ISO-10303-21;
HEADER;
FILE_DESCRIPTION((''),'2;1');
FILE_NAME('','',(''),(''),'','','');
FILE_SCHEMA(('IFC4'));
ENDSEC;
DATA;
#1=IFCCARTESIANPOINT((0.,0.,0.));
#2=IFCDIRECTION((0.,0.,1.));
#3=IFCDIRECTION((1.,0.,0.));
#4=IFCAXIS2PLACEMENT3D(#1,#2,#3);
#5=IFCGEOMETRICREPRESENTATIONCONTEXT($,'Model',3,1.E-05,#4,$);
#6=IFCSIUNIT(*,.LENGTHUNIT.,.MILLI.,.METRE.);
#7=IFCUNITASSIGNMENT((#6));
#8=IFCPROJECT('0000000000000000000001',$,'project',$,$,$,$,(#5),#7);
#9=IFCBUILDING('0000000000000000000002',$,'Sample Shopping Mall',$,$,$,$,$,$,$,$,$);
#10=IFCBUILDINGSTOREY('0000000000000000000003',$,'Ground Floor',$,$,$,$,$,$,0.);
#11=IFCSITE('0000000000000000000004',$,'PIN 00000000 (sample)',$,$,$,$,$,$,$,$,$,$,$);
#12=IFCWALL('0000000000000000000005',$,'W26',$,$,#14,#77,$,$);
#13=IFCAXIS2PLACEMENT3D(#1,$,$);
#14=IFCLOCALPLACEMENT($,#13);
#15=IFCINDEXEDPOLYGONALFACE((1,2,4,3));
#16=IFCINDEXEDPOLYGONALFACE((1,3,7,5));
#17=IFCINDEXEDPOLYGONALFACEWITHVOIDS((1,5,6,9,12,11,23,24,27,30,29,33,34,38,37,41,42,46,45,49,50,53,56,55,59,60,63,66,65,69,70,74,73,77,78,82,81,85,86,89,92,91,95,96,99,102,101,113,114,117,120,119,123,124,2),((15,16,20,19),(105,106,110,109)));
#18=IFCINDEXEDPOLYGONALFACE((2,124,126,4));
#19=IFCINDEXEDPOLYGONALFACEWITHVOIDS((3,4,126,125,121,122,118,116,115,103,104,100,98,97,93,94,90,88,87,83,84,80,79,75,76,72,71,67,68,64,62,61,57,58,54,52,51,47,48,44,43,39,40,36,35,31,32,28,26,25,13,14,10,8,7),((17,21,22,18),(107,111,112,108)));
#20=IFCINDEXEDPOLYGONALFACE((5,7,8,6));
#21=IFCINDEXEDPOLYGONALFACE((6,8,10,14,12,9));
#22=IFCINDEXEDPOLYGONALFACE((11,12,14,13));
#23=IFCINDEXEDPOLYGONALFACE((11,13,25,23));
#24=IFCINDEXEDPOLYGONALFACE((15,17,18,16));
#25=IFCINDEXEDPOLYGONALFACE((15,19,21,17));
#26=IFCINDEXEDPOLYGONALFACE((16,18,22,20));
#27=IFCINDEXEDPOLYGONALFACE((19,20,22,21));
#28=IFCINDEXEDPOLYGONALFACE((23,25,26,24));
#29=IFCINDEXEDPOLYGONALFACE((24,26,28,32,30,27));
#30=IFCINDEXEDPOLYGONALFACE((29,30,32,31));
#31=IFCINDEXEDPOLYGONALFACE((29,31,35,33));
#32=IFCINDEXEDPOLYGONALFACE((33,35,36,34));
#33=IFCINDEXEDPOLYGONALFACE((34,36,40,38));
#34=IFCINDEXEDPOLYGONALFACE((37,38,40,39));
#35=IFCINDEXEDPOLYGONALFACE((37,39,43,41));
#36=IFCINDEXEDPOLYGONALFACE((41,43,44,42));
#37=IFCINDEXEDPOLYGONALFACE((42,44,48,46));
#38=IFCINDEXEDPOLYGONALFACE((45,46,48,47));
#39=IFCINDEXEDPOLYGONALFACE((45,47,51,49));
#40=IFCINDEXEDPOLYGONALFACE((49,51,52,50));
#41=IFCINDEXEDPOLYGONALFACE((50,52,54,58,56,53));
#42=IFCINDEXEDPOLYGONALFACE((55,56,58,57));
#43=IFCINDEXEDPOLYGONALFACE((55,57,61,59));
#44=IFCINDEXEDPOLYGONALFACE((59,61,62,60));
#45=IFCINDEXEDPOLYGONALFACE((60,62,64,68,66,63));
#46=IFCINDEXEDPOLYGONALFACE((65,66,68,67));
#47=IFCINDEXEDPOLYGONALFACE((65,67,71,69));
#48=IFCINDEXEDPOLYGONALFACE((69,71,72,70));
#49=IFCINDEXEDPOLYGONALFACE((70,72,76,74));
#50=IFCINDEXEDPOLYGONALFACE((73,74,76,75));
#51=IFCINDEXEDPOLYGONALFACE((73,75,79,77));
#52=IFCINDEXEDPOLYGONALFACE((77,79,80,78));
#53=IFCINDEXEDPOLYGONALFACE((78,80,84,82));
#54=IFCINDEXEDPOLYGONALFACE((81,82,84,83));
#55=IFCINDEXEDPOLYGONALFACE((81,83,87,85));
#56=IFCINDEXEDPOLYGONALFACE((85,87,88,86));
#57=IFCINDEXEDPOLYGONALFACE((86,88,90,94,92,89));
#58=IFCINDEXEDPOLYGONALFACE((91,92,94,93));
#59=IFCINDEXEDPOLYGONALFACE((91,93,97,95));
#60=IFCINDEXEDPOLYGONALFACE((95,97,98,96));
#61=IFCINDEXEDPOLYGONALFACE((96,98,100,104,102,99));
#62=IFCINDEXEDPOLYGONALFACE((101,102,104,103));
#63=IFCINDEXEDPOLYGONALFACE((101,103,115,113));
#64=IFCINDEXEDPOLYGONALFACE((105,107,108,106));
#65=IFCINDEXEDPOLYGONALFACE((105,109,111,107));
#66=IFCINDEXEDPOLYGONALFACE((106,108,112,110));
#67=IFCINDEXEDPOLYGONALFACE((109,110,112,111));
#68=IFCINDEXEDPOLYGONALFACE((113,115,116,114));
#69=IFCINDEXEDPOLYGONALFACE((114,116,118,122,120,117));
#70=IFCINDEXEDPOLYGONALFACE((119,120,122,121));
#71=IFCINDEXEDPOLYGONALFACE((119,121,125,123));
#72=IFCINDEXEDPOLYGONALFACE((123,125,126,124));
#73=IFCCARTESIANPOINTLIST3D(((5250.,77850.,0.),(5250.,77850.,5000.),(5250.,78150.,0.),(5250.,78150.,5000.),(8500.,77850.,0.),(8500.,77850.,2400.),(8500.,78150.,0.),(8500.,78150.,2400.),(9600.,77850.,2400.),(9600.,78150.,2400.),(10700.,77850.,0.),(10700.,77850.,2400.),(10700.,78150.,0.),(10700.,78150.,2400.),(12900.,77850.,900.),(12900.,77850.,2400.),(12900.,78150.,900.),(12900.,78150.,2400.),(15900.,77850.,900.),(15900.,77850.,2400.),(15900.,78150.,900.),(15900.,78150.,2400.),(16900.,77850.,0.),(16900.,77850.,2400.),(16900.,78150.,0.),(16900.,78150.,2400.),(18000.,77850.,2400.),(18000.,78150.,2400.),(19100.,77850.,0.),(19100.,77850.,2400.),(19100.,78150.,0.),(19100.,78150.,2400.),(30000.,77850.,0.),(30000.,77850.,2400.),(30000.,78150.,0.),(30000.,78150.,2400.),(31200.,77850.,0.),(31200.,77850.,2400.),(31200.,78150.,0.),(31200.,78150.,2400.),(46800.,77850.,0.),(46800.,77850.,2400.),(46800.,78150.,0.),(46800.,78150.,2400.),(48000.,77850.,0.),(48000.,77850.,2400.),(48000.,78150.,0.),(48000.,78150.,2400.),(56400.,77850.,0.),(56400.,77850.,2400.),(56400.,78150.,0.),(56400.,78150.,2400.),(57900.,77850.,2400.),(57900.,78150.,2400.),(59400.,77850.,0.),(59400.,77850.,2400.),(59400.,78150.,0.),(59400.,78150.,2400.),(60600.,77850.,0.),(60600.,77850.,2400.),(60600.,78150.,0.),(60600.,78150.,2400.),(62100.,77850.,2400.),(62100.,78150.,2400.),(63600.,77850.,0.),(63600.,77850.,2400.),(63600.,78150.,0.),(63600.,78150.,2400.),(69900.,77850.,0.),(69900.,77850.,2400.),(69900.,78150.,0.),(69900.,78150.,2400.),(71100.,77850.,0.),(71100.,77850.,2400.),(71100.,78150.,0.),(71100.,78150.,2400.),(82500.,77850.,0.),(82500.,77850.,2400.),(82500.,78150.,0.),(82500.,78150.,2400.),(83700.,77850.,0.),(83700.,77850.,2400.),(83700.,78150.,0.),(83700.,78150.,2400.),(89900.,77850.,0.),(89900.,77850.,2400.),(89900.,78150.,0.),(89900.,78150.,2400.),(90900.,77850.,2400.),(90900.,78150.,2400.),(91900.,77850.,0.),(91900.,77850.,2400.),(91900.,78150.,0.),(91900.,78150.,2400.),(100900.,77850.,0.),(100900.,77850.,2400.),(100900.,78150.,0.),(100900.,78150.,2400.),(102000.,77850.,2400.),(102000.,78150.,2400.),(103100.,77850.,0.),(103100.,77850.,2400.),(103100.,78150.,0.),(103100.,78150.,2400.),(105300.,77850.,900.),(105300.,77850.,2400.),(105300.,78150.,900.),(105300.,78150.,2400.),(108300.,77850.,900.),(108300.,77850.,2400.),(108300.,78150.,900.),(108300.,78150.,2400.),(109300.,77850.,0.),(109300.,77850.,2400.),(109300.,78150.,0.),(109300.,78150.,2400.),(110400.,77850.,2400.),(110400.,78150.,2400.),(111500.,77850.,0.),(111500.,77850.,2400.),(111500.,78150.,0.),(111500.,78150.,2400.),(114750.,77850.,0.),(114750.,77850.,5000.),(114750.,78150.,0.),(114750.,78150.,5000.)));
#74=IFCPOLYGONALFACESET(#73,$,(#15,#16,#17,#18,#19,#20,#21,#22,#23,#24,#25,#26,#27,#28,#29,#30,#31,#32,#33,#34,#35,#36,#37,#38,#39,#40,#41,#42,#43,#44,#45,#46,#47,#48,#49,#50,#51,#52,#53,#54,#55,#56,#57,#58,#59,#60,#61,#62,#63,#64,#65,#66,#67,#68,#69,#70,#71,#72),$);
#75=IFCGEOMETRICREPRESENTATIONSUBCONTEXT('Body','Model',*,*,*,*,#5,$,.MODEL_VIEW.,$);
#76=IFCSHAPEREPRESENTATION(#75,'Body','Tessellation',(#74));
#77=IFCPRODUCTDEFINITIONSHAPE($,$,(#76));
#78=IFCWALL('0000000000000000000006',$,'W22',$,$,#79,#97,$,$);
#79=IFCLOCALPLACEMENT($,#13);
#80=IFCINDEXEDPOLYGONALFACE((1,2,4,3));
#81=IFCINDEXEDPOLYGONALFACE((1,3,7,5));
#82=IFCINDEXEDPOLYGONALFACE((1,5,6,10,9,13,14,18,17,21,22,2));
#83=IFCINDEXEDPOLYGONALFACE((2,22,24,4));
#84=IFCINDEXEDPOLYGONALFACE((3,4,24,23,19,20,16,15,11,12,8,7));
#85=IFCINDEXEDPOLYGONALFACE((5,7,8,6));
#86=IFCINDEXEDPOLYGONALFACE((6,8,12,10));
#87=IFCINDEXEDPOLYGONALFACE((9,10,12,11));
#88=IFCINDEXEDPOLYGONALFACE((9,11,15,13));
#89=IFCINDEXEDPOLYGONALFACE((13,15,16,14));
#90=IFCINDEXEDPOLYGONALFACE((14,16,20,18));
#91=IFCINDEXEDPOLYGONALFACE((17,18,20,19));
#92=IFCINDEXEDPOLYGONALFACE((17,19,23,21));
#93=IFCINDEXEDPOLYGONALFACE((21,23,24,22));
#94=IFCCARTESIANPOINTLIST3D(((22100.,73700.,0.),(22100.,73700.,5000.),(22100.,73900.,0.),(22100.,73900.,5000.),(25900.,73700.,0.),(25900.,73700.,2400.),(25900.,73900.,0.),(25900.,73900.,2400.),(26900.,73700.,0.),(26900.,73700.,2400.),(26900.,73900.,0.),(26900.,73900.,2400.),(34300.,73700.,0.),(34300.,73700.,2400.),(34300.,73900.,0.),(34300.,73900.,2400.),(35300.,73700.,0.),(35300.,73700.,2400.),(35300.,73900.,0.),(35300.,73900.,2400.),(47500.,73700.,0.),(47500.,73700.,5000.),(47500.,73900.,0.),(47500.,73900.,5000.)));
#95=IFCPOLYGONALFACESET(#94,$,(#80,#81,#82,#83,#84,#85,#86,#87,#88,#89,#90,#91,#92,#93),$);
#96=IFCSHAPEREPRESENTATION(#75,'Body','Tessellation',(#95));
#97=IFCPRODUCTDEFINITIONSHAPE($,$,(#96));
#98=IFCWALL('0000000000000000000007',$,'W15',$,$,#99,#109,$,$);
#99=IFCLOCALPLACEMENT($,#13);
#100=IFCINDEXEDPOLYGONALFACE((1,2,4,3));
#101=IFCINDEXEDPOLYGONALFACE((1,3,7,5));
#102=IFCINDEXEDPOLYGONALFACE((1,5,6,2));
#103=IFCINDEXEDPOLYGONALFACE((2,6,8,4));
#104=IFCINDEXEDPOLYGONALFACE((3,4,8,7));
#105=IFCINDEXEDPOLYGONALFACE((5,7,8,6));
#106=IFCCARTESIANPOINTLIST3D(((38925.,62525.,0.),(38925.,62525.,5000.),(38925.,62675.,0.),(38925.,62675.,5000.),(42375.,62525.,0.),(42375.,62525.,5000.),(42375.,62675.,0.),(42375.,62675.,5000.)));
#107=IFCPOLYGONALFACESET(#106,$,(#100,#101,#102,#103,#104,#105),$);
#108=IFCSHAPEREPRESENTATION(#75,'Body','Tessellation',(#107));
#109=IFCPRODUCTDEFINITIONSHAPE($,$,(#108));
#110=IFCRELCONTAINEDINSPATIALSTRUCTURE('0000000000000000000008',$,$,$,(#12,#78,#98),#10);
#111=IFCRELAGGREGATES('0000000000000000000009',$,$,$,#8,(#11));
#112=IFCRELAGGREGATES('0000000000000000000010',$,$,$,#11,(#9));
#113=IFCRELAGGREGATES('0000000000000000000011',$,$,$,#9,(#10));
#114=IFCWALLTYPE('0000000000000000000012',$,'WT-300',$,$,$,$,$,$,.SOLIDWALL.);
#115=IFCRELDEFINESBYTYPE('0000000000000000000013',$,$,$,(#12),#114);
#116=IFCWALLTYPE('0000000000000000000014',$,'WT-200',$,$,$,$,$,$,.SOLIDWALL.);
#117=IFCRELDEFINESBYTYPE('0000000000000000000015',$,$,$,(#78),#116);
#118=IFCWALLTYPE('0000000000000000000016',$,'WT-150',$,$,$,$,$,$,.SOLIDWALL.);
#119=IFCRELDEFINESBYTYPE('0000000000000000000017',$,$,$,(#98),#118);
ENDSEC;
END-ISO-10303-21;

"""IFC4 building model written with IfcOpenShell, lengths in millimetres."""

from ifc_helpers import new_model, si_unit, frame, origin_with_axes, place, context, subcontext, project, spatial, indexed_curve, outline, extrude, type_object, element, save


model = new_model("IFC4")

# Units and contexts
model_context = context("Model", 3, precision=1e-05, world=origin_with_axes())
body_context = subcontext(model_context, "Body", "Model", "MODEL_VIEW")
ifc_project = project(units=[si_unit("LENGTHUNIT", "METRE", prefix="MILLI")], contexts=[model_context])

# Site, building, storey
site = spatial("IfcSite", under=ifc_project, Name="PIN 00000000 (sample)")
building = spatial("IfcBuilding", under=site, Name="Sample Shopping Mall")
storey = spatial("IfcBuildingStorey", under=building, Name="Ground Floor", Elevation=0.0)

# Walls, openings
wall_type_1 = type_object("IfcWallType", Name="WT-300", PredefinedType="SOLIDWALL")
wall_1_placement = place(None, frame((5250.0, 77850.0, 0.0), z_axis=(0.0, 0.0, 1.0), x_axis=(1.0, 0.0, 0.0)))
wall_1 = element("IfcWall", 1, at=wall_1_placement, inside=storey, type_object=wall_type_1, Name="W26", context=body_context, shape_type="SweptSolid", body=[
    extrude(outline(indexed_curve([(0.0, 0.0), (0.0, 300.0), (109500.0, 300.0), (109500.0, 0.0), (0.0, 0.0)], self_intersect=False)), origin_with_axes(), (0.0, 0.0, 1.0), 5000.0),
])
opening_1_placement = place(wall_1_placement, frame((3250.0, -100.0, 0.0), z_axis=(0.0, 0.0, 1.0), x_axis=(1.0, 0.0, 0.0)))
element("IfcOpeningElement", 2, at=opening_1_placement, cuts=wall_1, context=body_context, shape_type="SweptSolid", body=[
    extrude(outline(indexed_curve([(0.0, 0.0), (0.0, 500.0), (1100.0, 500.0), (1100.0, 0.0), (0.0, 0.0)], self_intersect=False)), origin_with_axes(), (0.0, 0.0, 1.0), 2400.0),
])
opening_2_placement = place(wall_1_placement, frame((4350.0, -100.0, 0.0), z_axis=(0.0, 0.0, 1.0), x_axis=(1.0, 0.0, 0.0)))
element("IfcOpeningElement", 3, at=opening_2_placement, cuts=wall_1, context=body_context, shape_type="SweptSolid", body=[
    extrude(outline(indexed_curve([(0.0, 0.0), (0.0, 500.0), (1100.0, 500.0), (1100.0, 0.0), (0.0, 0.0)], self_intersect=False)), origin_with_axes(), (0.0, 0.0, 1.0), 2400.0),
])
opening_3_placement = place(wall_1_placement, frame((11650.0, -100.0, 0.0), z_axis=(0.0, 0.0, 1.0), x_axis=(1.0, 0.0, 0.0)))
element("IfcOpeningElement", 4, at=opening_3_placement, cuts=wall_1, context=body_context, shape_type="SweptSolid", body=[
    extrude(outline(indexed_curve([(0.0, 0.0), (0.0, 500.0), (1100.0, 500.0), (1100.0, 0.0), (0.0, 0.0)], self_intersect=False)), origin_with_axes(), (0.0, 0.0, 1.0), 2400.0),
])
opening_4_placement = place(wall_1_placement, frame((12750.0, -100.0, 0.0), z_axis=(0.0, 0.0, 1.0), x_axis=(1.0, 0.0, 0.0)))
element("IfcOpeningElement", 5, at=opening_4_placement, cuts=wall_1, context=body_context, shape_type="SweptSolid", body=[
    extrude(outline(indexed_curve([(0.0, 0.0), (0.0, 500.0), (1100.0, 500.0), (1100.0, 0.0), (0.0, 0.0)], self_intersect=False)), origin_with_axes(), (0.0, 0.0, 1.0), 2400.0),
])
opening_5_placement = place(wall_1_placement, frame((95650.0, -100.0, 0.0), z_axis=(0.0, 0.0, 1.0), x_axis=(1.0, 0.0, 0.0)))
element("IfcOpeningElement", 6, at=opening_5_placement, cuts=wall_1, context=body_context, shape_type="SweptSolid", body=[
    extrude(outline(indexed_curve([(0.0, 0.0), (0.0, 500.0), (1100.0, 500.0), (1100.0, 0.0), (0.0, 0.0)], self_intersect=False)), origin_with_axes(), (0.0, 0.0, 1.0), 2400.0),
])
opening_6_placement = place(wall_1_placement, frame((96750.0, -100.0, 0.0), z_axis=(0.0, 0.0, 1.0), x_axis=(1.0, 0.0, 0.0)))
element("IfcOpeningElement", 7, at=opening_6_placement, cuts=wall_1, context=body_context, shape_type="SweptSolid", body=[
    extrude(outline(indexed_curve([(0.0, 0.0), (0.0, 500.0), (1100.0, 500.0), (1100.0, 0.0), (0.0, 0.0)], self_intersect=False)), origin_with_axes(), (0.0, 0.0, 1.0), 2400.0),
])
opening_7_placement = place(wall_1_placement, frame((104050.0, -100.0, 0.0), z_axis=(0.0, 0.0, 1.0), x_axis=(1.0, 0.0, 0.0)))
element("IfcOpeningElement", 8, at=opening_7_placement, cuts=wall_1, context=body_context, shape_type="SweptSolid", body=[
    extrude(outline(indexed_curve([(0.0, 0.0), (0.0, 500.0), (1100.0, 500.0), (1100.0, 0.0), (0.0, 0.0)], self_intersect=False)), origin_with_axes(), (0.0, 0.0, 1.0), 2400.0),
])
opening_8_placement = place(wall_1_placement, frame((105150.0, -100.0, 0.0), z_axis=(0.0, 0.0, 1.0), x_axis=(1.0, 0.0, 0.0)))
element("IfcOpeningElement", 9, at=opening_8_placement, cuts=wall_1, context=body_context, shape_type="SweptSolid", body=[
    extrude(outline(indexed_curve([(0.0, 0.0), (0.0, 500.0), (1100.0, 500.0), (1100.0, 0.0), (0.0, 0.0)], self_intersect=False)), origin_with_axes(), (0.0, 0.0, 1.0), 2400.0),
])
opening_9_placement = place(wall_1_placement, frame((24750.0, -100.0, 0.0), z_axis=(0.0, 0.0, 1.0), x_axis=(1.0, 0.0, 0.0)))
element("IfcOpeningElement", 10, at=opening_9_placement, cuts=wall_1, context=body_context, shape_type="SweptSolid", body=[
    extrude(outline(indexed_curve([(0.0, 0.0), (0.0, 500.0), (1200.0, 500.0), (1200.0, 0.0), (0.0, 0.0)], self_intersect=False)), origin_with_axes(), (0.0, 0.0, 1.0), 2400.0),
])
opening_10_placement = place(wall_1_placement, frame((41550.0, -100.0, 0.0), z_axis=(0.0, 0.0, 1.0), x_axis=(1.0, 0.0, 0.0)))
element("IfcOpeningElement", 11, at=opening_10_placement, cuts=wall_1, context=body_context, shape_type="SweptSolid", body=[
    extrude(outline(indexed_curve([(0.0, 0.0), (0.0, 500.0), (1200.0, 500.0), (1200.0, 0.0), (0.0, 0.0)], self_intersect=False)), origin_with_axes(), (0.0, 0.0, 1.0), 2400.0),
])
opening_11_placement = place(wall_1_placement, frame((64650.0, -100.0, 0.0), z_axis=(0.0, 0.0, 1.0), x_axis=(1.0, 0.0, 0.0)))
element("IfcOpeningElement", 12, at=opening_11_placement, cuts=wall_1, context=body_context, shape_type="SweptSolid", body=[
    extrude(outline(indexed_curve([(0.0, 0.0), (0.0, 500.0), (1200.0, 500.0), (1200.0, 0.0), (0.0, 0.0)], self_intersect=False)), origin_with_axes(), (0.0, 0.0, 1.0), 2400.0),
])
opening_12_placement = place(wall_1_placement, frame((77250.0, -100.0, 0.0), z_axis=(0.0, 0.0, 1.0), x_axis=(1.0, 0.0, 0.0)))
element("IfcOpeningElement", 13, at=opening_12_placement, cuts=wall_1, context=body_context, shape_type="SweptSolid", body=[
    extrude(outline(indexed_curve([(0.0, 0.0), (0.0, 500.0), (1200.0, 500.0), (1200.0, 0.0), (0.0, 0.0)], self_intersect=False)), origin_with_axes(), (0.0, 0.0, 1.0), 2400.0),
])
opening_13_placement = place(wall_1_placement, frame((51150.0, -100.0, 0.0), z_axis=(0.0, 0.0, 1.0), x_axis=(1.0, 0.0, 0.0)))
element("IfcOpeningElement", 14, at=opening_13_placement, cuts=wall_1, context=body_context, shape_type="SweptSolid", body=[
    extrude(outline(indexed_curve([(0.0, 0.0), (0.0, 500.0), (1500.0, 500.0), (1500.0, 0.0), (0.0, 0.0)], self_intersect=False)), origin_with_axes(), (0.0, 0.0, 1.0), 2400.0),
])
opening_14_placement = place(wall_1_placement, frame((52650.0, -100.0, 0.0), z_axis=(0.0, 0.0, 1.0), x_axis=(1.0, 0.0, 0.0)))
element("IfcOpeningElement", 15, at=opening_14_placement, cuts=wall_1, context=body_context, shape_type="SweptSolid", body=[
    extrude(outline(indexed_curve([(0.0, 0.0), (0.0, 500.0), (1500.0, 500.0), (1500.0, 0.0), (0.0, 0.0)], self_intersect=False)), origin_with_axes(), (0.0, 0.0, 1.0), 2400.0),
])
opening_15_placement = place(wall_1_placement, frame((55350.0, -100.0, 0.0), z_axis=(0.0, 0.0, 1.0), x_axis=(1.0, 0.0, 0.0)))
element("IfcOpeningElement", 16, at=opening_15_placement, cuts=wall_1, context=body_context, shape_type="SweptSolid", body=[
    extrude(outline(indexed_curve([(0.0, 0.0), (0.0, 500.0), (1500.0, 500.0), (1500.0, 0.0), (0.0, 0.0)], self_intersect=False)), origin_with_axes(), (0.0, 0.0, 1.0), 2400.0),
])
opening_16_placement = place(wall_1_placement, frame((56850.0, -100.0, 0.0), z_axis=(0.0, 0.0, 1.0), x_axis=(1.0, 0.0, 0.0)))
element("IfcOpeningElement", 17, at=opening_16_placement, cuts=wall_1, context=body_context, shape_type="SweptSolid", body=[
    extrude(outline(indexed_curve([(0.0, 0.0), (0.0, 500.0), (1500.0, 500.0), (1500.0, 0.0), (0.0, 0.0)], self_intersect=False)), origin_with_axes(), (0.0, 0.0, 1.0), 2400.0),
])
opening_17_placement = place(wall_1_placement, frame((84650.0, -100.0, 0.0), z_axis=(0.0, 0.0, 1.0), x_axis=(1.0, 0.0, 0.0)))
element("IfcOpeningElement", 18, at=opening_17_placement, cuts=wall_1, context=body_context, shape_type="SweptSolid", body=[
    extrude(outline(indexed_curve([(0.0, 0.0), (0.0, 500.0), (1000.0, 500.0), (1000.0, 0.0), (0.0, 0.0)], self_intersect=False)), origin_with_axes(), (0.0, 0.0, 1.0), 2400.0),
])
opening_18_placement = place(wall_1_placement, frame((85650.0, -100.0, 0.0), z_axis=(0.0, 0.0, 1.0), x_axis=(1.0, 0.0, 0.0)))
element("IfcOpeningElement", 19, at=opening_18_placement, cuts=wall_1, context=body_context, shape_type="SweptSolid", body=[
    extrude(outline(indexed_curve([(0.0, 0.0), (0.0, 500.0), (1000.0, 500.0), (1000.0, 0.0), (0.0, 0.0)], self_intersect=False)), origin_with_axes(), (0.0, 0.0, 1.0), 2400.0),
])
opening_19_placement = place(wall_1_placement, frame((7650.0, -100.0, 900.0), z_axis=(0.0, 0.0, 1.0), x_axis=(1.0, 0.0, 0.0)))
element("IfcOpeningElement", 20, at=opening_19_placement, cuts=wall_1, context=body_context, shape_type="SweptSolid", body=[
    extrude(outline(indexed_curve([(0.0, 0.0), (0.0, 500.0), (3000.0, 500.0), (3000.0, 0.0), (0.0, 0.0)], self_intersect=False)), origin_with_axes(), (0.0, 0.0, 1.0), 1500.0),
])
opening_20_placement = place(wall_1_placement, frame((100050.0, -100.0, 900.0), z_axis=(0.0, 0.0, 1.0), x_axis=(1.0, 0.0, 0.0)))
element("IfcOpeningElement", 21, at=opening_20_placement, cuts=wall_1, context=body_context, shape_type="SweptSolid", body=[
    extrude(outline(indexed_curve([(0.0, 0.0), (0.0, 500.0), (3000.0, 500.0), (3000.0, 0.0), (0.0, 0.0)], self_intersect=False)), origin_with_axes(), (0.0, 0.0, 1.0), 1500.0),
])
wall_type_2 = type_object("IfcWallType", Name="WT-200", PredefinedType="SOLIDWALL")
wall_2_placement = place(None, frame((22100.0, 73700.0, 0.0), z_axis=(0.0, 0.0, 1.0), x_axis=(1.0, 0.0, 0.0)))
wall_2 = element("IfcWall", 22, at=wall_2_placement, inside=storey, type_object=wall_type_2, Name="W22", context=body_context, shape_type="SweptSolid", body=[
    extrude(outline(indexed_curve([(0.0, 0.0), (0.0, 200.0), (25400.0, 200.0), (25400.0, 0.0), (0.0, 0.0)], self_intersect=False)), origin_with_axes(), (0.0, 0.0, 1.0), 5000.0),
])
opening_21_placement = place(wall_2_placement, frame((3800.0, -100.0, 0.0), z_axis=(0.0, 0.0, 1.0), x_axis=(1.0, 0.0, 0.0)))
element("IfcOpeningElement", 23, at=opening_21_placement, cuts=wall_2, context=body_context, shape_type="SweptSolid", body=[
    extrude(outline(indexed_curve([(0.0, 0.0), (0.0, 400.0), (1000.0, 400.0), (1000.0, 0.0), (0.0, 0.0)], self_intersect=False)), origin_with_axes(), (0.0, 0.0, 1.0), 2400.0),
])
opening_22_placement = place(wall_2_placement, frame((12200.0, -100.0, 0.0), z_axis=(0.0, 0.0, 1.0), x_axis=(1.0, 0.0, 0.0)))
element("IfcOpeningElement", 24, at=opening_22_placement, cuts=wall_2, context=body_context, shape_type="SweptSolid", body=[
    extrude(outline(indexed_curve([(0.0, 0.0), (0.0, 400.0), (1000.0, 400.0), (1000.0, 0.0), (0.0, 0.0)], self_intersect=False)), origin_with_axes(), (0.0, 0.0, 1.0), 2400.0),
])

# Wall
wall_type_3 = type_object("IfcWallType", Name="WT-150", PredefinedType="SOLIDWALL")
for number, where, z_axis, x_axis, name in (
    (25, (38925.0, 62525.0, 0.0), (0.0, 0.0, 1.0), (1.0, 0.0, 0.0), "W15"),
):
    element("IfcWall", number, at=place(None, frame(where, z_axis=z_axis, x_axis=x_axis)), inside=storey, type_object=wall_type_3, Name=name, context=body_context, shape_type="SweptSolid", body=[
        extrude(outline(indexed_curve([(0.0, 0.0), (0.0, 150.0), (3450.0, 150.0), (3450.0, 0.0), (0.0, 0.0)], self_intersect=False)), origin_with_axes(), (0.0, 0.0, 1.0), 5000.0),
    ])

save(model, "model.ifc")
